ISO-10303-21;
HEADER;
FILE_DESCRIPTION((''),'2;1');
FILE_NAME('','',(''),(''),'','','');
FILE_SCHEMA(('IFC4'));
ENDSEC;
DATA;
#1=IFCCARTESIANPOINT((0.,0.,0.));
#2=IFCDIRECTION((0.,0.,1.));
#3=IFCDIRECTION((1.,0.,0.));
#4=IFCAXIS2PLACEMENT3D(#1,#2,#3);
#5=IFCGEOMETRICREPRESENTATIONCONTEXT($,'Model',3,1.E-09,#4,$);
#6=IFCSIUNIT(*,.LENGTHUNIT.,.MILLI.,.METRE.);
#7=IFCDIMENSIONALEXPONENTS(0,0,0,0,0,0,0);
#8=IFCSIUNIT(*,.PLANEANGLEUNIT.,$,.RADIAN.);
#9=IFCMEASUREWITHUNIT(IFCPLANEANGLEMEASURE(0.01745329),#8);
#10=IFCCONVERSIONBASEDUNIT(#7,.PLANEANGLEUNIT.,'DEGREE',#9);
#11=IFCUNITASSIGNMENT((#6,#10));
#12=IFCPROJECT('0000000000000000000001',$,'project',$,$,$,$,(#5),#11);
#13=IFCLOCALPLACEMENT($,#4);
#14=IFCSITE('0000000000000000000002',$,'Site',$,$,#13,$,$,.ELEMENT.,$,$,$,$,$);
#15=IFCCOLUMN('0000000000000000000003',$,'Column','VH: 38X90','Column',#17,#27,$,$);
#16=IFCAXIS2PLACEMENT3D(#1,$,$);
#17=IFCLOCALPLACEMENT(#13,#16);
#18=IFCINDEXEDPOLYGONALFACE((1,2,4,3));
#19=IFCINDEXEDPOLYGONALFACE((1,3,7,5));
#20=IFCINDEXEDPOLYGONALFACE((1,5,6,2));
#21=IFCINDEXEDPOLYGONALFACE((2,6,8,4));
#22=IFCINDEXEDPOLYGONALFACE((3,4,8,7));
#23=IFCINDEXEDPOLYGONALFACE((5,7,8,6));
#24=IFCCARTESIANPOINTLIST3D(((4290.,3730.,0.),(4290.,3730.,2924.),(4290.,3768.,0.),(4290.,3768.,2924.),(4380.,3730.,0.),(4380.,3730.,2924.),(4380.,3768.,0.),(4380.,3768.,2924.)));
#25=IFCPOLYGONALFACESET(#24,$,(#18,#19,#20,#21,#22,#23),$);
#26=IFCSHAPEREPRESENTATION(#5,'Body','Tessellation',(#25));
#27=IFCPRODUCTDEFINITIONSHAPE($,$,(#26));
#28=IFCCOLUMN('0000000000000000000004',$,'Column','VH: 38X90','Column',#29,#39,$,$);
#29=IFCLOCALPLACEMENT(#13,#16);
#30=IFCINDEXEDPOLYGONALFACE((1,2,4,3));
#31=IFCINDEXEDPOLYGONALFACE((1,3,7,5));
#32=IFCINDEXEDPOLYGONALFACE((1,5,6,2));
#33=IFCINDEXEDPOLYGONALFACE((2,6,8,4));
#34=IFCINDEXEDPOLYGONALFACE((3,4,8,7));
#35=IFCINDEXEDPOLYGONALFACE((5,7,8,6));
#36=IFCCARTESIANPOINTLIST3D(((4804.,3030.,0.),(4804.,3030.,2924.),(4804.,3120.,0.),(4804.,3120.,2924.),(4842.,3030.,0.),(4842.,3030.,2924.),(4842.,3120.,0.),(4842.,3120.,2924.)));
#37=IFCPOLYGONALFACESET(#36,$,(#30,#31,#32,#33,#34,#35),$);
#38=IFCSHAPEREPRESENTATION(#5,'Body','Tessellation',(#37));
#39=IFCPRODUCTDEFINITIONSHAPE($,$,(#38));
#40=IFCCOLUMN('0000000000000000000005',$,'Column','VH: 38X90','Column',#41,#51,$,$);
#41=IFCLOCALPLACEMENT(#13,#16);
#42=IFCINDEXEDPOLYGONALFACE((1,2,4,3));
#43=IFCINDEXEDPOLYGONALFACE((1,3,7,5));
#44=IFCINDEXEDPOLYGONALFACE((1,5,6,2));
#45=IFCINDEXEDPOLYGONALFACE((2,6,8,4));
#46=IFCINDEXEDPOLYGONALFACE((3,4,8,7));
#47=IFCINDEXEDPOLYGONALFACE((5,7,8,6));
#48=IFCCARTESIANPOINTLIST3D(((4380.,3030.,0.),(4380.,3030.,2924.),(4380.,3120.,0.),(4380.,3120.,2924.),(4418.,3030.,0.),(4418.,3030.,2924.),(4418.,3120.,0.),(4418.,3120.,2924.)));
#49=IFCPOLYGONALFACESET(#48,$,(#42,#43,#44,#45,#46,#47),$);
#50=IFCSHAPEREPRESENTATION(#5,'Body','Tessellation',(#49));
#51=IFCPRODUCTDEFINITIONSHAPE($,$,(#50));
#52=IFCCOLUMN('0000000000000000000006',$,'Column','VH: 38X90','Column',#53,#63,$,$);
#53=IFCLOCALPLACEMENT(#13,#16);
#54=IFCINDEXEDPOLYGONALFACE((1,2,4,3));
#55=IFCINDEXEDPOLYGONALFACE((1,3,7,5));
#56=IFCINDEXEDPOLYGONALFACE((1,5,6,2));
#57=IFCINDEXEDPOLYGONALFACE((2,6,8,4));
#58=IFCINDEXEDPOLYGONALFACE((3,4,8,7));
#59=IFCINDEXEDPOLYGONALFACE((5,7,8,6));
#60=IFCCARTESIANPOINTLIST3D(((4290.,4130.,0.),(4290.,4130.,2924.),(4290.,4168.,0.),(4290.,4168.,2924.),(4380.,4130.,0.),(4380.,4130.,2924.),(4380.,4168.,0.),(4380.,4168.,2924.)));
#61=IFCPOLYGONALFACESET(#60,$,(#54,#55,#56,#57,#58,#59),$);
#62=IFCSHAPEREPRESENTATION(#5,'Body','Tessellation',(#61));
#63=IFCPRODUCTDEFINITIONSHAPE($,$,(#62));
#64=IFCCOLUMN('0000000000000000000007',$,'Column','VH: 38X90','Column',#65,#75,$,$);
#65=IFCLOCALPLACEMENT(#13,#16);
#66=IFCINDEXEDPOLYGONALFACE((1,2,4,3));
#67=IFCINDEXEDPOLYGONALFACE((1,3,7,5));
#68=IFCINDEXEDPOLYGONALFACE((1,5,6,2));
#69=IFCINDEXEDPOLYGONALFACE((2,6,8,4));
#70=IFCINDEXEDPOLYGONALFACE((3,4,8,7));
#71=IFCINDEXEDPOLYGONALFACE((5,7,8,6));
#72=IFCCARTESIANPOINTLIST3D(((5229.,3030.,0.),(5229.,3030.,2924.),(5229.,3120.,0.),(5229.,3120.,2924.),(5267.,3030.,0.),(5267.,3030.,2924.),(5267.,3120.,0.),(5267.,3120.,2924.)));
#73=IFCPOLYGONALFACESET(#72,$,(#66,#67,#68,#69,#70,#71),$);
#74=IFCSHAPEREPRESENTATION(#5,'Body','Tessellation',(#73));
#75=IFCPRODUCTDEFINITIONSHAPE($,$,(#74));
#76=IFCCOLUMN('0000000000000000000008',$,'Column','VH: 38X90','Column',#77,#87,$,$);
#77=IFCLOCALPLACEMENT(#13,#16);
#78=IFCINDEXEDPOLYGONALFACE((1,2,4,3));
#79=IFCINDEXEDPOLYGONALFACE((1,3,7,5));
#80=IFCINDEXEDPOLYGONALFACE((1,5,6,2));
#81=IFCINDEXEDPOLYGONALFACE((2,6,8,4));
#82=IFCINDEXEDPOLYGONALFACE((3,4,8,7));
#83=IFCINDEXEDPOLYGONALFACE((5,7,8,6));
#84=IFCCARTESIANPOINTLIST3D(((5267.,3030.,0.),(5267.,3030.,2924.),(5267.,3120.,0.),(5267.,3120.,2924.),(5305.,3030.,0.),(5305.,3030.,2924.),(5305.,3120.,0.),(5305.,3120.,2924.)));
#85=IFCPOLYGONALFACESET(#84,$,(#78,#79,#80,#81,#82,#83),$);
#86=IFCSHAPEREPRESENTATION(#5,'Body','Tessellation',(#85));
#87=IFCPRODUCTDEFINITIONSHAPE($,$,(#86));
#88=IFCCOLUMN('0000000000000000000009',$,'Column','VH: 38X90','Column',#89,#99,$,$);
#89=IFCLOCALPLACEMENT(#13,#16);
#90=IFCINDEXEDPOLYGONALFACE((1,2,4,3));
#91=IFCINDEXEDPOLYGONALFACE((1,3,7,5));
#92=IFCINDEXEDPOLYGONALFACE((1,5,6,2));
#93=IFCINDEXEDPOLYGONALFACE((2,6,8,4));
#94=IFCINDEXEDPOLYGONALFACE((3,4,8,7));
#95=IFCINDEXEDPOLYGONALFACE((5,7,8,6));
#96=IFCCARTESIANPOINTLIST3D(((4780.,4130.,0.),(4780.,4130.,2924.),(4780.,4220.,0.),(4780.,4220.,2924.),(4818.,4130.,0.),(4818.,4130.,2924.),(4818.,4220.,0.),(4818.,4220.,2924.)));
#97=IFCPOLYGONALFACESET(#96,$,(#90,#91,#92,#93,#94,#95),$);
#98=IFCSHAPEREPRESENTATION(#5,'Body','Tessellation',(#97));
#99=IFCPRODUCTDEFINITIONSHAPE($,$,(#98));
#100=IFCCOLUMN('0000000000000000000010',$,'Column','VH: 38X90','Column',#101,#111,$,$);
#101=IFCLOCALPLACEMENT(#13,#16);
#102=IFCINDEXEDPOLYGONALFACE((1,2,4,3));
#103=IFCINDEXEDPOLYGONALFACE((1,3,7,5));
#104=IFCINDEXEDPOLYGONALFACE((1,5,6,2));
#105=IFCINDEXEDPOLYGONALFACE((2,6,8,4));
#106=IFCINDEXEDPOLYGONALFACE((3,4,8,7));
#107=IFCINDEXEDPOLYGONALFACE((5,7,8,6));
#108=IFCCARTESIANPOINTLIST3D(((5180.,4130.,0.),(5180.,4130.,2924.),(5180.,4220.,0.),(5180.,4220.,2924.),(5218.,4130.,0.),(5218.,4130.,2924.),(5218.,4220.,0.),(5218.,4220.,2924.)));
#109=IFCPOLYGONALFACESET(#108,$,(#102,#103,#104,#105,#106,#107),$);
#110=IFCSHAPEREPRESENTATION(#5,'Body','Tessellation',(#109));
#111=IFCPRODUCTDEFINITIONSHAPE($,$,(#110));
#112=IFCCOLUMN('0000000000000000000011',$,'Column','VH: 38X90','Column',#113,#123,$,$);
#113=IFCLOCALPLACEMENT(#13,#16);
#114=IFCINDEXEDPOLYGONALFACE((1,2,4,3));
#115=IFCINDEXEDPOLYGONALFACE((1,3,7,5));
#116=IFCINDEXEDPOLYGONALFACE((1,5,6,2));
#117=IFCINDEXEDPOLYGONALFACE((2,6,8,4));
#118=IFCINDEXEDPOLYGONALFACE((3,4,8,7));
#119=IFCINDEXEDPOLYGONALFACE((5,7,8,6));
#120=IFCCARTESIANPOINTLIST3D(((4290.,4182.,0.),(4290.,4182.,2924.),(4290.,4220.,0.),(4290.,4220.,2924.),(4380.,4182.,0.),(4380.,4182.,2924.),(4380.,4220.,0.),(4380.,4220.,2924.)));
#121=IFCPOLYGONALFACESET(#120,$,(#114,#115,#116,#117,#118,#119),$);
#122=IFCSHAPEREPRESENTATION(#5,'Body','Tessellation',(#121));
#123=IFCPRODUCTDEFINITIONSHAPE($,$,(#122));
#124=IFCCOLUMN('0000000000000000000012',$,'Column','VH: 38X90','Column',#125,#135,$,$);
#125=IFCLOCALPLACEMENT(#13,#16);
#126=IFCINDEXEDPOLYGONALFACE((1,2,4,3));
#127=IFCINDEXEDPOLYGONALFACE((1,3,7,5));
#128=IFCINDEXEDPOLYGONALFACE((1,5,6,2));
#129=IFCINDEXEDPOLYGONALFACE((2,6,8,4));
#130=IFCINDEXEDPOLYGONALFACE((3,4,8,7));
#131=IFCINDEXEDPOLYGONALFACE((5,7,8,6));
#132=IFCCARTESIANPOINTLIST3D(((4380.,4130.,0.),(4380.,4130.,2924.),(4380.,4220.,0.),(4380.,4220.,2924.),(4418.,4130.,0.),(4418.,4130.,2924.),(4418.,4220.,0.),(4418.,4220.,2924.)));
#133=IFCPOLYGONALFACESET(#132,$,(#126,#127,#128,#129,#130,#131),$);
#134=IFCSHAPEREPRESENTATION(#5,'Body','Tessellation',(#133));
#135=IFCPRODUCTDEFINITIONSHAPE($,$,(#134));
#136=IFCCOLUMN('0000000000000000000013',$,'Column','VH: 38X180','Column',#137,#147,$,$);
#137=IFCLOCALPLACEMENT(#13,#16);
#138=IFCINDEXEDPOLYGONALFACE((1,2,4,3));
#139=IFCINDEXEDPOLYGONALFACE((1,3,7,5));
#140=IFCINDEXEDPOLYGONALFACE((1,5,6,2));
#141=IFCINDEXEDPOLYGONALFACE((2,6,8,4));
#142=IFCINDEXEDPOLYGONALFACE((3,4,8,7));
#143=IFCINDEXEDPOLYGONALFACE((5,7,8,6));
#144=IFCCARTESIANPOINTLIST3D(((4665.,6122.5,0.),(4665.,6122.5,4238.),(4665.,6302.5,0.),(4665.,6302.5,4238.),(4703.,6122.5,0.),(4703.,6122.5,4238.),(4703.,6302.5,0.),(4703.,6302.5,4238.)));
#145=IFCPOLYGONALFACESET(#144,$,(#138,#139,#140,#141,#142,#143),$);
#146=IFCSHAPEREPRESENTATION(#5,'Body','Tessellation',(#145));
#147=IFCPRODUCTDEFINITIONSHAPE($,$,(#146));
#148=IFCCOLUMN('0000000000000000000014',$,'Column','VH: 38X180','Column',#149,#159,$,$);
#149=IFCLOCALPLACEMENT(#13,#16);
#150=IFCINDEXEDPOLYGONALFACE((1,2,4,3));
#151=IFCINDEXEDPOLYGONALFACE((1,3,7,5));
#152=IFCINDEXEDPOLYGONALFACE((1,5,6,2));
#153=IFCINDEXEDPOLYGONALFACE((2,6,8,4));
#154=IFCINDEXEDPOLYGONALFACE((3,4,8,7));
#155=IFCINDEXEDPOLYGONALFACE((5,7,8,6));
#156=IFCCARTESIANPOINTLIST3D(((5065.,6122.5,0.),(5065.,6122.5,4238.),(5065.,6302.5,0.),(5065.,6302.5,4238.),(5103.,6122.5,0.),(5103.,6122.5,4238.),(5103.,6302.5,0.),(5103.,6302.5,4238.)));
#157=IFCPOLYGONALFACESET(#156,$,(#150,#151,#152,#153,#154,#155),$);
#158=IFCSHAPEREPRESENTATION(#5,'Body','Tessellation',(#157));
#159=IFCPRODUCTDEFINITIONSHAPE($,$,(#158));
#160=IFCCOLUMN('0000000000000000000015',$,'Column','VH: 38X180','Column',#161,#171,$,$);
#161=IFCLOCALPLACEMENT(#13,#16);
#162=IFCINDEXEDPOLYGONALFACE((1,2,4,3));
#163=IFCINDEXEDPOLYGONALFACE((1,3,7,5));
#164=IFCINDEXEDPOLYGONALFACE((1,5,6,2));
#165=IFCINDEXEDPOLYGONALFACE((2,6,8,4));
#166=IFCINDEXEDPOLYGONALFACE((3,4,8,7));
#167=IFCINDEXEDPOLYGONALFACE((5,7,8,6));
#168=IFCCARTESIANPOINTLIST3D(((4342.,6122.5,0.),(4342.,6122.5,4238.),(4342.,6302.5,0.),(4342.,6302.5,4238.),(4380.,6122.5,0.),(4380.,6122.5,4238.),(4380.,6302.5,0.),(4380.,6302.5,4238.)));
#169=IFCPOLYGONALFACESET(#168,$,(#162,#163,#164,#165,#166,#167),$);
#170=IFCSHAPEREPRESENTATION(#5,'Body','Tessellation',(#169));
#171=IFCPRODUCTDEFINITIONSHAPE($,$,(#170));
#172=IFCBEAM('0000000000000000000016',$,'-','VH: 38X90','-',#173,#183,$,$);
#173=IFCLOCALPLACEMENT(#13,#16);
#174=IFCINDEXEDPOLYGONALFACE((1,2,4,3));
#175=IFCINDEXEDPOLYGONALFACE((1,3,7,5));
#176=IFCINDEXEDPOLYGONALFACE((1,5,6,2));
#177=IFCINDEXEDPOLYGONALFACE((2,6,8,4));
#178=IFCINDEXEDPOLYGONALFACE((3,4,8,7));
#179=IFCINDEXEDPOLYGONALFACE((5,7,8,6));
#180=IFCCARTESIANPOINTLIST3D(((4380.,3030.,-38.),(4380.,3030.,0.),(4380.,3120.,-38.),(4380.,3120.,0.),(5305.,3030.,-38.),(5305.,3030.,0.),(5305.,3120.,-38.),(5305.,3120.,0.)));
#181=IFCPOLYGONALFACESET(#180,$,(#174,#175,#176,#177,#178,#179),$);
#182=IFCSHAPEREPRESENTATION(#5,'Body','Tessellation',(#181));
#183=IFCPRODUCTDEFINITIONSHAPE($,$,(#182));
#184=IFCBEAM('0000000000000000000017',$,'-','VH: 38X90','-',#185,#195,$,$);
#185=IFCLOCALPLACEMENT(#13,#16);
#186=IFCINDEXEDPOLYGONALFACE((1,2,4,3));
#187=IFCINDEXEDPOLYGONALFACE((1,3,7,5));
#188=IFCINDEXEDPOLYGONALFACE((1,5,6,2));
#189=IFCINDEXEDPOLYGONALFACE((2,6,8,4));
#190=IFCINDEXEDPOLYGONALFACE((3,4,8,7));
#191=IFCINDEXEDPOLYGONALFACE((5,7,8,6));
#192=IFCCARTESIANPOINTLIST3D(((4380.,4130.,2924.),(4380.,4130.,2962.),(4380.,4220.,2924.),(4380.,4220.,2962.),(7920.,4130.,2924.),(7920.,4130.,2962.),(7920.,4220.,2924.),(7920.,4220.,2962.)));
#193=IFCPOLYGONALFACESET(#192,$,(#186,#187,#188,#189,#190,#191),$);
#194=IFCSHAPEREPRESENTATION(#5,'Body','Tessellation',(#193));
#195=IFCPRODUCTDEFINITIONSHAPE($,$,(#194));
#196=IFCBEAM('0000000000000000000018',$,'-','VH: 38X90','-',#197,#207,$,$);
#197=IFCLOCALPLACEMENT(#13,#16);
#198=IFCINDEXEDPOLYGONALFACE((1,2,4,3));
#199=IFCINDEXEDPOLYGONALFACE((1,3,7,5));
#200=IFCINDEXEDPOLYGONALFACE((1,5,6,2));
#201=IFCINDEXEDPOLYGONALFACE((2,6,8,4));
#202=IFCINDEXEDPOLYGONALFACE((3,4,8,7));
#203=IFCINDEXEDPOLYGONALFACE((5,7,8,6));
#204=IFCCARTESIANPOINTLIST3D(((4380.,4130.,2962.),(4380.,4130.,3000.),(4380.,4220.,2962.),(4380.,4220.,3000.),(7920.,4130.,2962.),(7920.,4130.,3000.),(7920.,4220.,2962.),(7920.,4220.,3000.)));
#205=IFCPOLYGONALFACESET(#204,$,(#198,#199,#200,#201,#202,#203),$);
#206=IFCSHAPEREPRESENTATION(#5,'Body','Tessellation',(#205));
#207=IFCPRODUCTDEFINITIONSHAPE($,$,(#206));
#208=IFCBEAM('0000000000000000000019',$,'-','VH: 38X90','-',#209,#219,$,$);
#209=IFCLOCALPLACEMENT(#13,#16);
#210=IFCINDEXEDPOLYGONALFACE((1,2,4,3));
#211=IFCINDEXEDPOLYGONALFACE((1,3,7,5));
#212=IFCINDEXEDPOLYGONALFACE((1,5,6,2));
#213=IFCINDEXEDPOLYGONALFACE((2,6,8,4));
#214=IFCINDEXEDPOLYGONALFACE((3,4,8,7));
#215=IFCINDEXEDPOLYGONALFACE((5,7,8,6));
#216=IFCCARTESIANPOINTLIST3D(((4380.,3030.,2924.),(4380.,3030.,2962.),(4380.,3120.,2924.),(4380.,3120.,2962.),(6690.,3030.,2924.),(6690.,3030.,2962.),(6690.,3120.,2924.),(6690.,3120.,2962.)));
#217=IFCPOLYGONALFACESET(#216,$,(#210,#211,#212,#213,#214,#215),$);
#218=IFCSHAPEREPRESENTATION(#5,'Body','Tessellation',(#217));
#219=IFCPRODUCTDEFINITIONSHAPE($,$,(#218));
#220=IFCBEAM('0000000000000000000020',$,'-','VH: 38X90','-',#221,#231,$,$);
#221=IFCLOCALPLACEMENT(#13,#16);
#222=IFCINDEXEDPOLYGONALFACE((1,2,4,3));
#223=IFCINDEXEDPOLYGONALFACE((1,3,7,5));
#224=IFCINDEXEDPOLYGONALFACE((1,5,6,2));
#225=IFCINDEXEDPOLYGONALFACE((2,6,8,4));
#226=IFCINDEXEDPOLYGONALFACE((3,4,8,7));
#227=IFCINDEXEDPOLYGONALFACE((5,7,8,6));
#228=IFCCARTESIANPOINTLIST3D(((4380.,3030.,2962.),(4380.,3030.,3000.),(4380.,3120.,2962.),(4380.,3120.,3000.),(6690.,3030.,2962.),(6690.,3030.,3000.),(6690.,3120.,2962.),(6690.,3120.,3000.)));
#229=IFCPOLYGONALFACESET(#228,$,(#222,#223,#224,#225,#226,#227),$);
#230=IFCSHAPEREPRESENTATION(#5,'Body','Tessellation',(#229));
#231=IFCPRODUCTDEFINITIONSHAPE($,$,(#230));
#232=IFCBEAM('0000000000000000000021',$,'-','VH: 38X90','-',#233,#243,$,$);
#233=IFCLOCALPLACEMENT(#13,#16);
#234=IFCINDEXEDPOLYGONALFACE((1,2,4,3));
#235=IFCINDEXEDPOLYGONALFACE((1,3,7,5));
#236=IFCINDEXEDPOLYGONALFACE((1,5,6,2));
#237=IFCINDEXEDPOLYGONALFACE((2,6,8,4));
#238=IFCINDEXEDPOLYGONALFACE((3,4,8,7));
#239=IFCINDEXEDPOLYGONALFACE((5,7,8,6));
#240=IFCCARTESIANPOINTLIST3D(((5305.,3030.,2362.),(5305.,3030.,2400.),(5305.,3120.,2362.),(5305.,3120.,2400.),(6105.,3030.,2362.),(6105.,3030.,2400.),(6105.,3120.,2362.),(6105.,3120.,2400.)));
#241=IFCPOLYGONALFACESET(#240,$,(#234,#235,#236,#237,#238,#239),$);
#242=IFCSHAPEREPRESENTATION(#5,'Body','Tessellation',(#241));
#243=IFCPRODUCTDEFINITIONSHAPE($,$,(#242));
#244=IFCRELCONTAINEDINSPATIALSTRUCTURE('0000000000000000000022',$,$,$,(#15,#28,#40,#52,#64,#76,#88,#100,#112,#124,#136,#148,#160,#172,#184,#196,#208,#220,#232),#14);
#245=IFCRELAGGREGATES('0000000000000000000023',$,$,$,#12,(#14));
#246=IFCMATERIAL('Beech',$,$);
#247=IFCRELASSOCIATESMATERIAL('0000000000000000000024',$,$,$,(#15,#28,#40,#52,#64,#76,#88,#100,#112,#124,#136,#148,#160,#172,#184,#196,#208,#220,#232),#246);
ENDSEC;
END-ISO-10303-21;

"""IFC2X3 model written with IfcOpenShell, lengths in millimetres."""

from ifc_helpers import new_model, entity, si_unit, converted_unit, frame, origin, origin_with_axes, origin_2d, place, context, project, spatial, rectangle, extrude, material, element, save


model = new_model("IFC2X3")

# Units and contexts
model_context = context("Model", 3, precision=1e-09, world=origin_with_axes())
ifc_project = project(units=[si_unit("LENGTHUNIT", "METRE", prefix="MILLI"), converted_unit("PLANEANGLEUNIT", "DEGREE", entity("IfcPlaneAngleMeasure", 0.01745329), si_unit("PLANEANGLEUNIT", "RADIAN"), dimensions=[0, 0, 0, 0, 0, 0, 0])], contexts=[model_context])

# Site
site_placement = place(None, origin_with_axes())
site = spatial("IfcSite", under=ifc_project, at=site_placement, Name="Site", CompositionType="ELEMENT")

# Columns
ifc_material = material(Name="Beech")
for number, where, z_axis, x_axis, name in (
    (1, (4335.0, 3749.0, 0.0), (0.0, 0.0, -1.0), (0.0, -1.0, 0.0), "Column"),
    (2, (4823.0, 3075.0, 0.0), (0.0, 0.0, -1.0), (-1.0, 0.0, 0.0), "Column"),
    (3, (4399.0, 3075.0, 0.0), (0.0, 0.0, -1.0), (-1.0, 0.0, 0.0), "Column"),
    (4, (4335.0, 4149.0, 0.0), (0.0, 0.0, -1.0), (0.0, -1.0, 0.0), "Column"),
    (5, (5248.0, 3075.0, 0.0), (0.0, 0.0, -1.0), (-1.0, 0.0, 0.0), "Column"),
    (6, (5286.0, 3075.0, 0.0), (0.0, 0.0, -1.0), (-1.0, 0.0, 0.0), "Column"),
    (7, (4799.0, 4175.0, 0.0), (0.0, 0.0, -1.0), (-1.0, 0.0, 0.0), "Column"),
    (8, (5199.0, 4175.0, 0.0), (0.0, 0.0, -1.0), (-1.0, 0.0, 0.0), "Column"),
    (9, (4335.0, 4201.0, 0.0), (0.0, 0.0, -1.0), (0.0, -1.0, 0.0), "Column"),
    (10, (4399.0, 4175.0, 0.0), (0.0, 0.0, -1.0), (-1.0, 0.0, 0.0), "Column"),
):
    element("IfcColumn", number, at=place(None, frame(where, z_axis=z_axis, x_axis=x_axis)), inside=site, material=ifc_material, Name=name, Description="VH: 38X90", ObjectType="Column", context=model_context, shape_type="SweptSolid", body=[
        extrude(rectangle(XDim=38.0, YDim=90.0, at=origin_2d()), origin(), (0.0, 0.0, -1.0), 2924.0),
    ])
for number, where, z_axis, x_axis, name in (
    (11, (4684.0, 6212.5, 0.0), (0.0, 0.0, -1.0), (-1.0, 0.0, 0.0), "Column"),
    (12, (5084.0, 6212.5, 0.0), (0.0, 0.0, -1.0), (-1.0, 0.0, 0.0), "Column"),
    (13, (4361.0, 6212.5, 0.0), (0.0, 0.0, -1.0), (-1.0, 0.0, 0.0), "Column"),
):
    element("IfcColumn", number, at=place(None, frame(where, z_axis=z_axis, x_axis=x_axis)), inside=site, material=ifc_material, Name=name, Description="VH: 38X180", ObjectType="Column", context=model_context, shape_type="SweptSolid", body=[
        extrude(rectangle(XDim=38.0, YDim=180.0, at=origin_2d()), origin(), (0.0, 0.0, -1.0), 4238.0),
    ])

# Beams
beam_1_placement = place(None, frame((4380.0, 3075.0, -19.0), z_axis=(-1.0, 0.0, 0.0), x_axis=(0.0, 0.0, -1.0)))
element("IfcBeam", 14, at=beam_1_placement, inside=site, material=ifc_material, Name="-", Description="VH: 38X90", ObjectType="-", context=model_context, shape_type="SweptSolid", body=[
    extrude(rectangle(XDim=38.0, YDim=90.0, at=origin_2d()), origin(), (0.0, 0.0, -1.0), 925.0),
])
for number, where, z_axis, x_axis, name in (
    (15, (4380.0, 4175.0, 2943.0), (-1.0, 0.0, 0.0), (0.0, 0.0, -1.0), "-"),
    (16, (4380.0, 4175.0, 2981.0), (-1.0, 0.0, 0.0), (0.0, 0.0, -1.0), "-"),
):
    element("IfcBeam", number, at=place(None, frame(where, z_axis=z_axis, x_axis=x_axis)), inside=site, material=ifc_material, Name=name, Description="VH: 38X90", ObjectType="-", context=model_context, shape_type="SweptSolid", body=[
        extrude(rectangle(XDim=38.0, YDim=90.0, at=origin_2d()), origin(), (0.0, 0.0, -1.0), 3540.0),
    ])
for number, where, z_axis, x_axis, name in (
    (17, (4380.0, 3075.0, 2943.0), (-1.0, 0.0, 0.0), (0.0, 0.0, -1.0), "-"),
    (18, (4380.0, 3075.0, 2981.0), (-1.0, 0.0, 0.0), (0.0, 0.0, -1.0), "-"),
):
    element("IfcBeam", number, at=place(None, frame(where, z_axis=z_axis, x_axis=x_axis)), inside=site, material=ifc_material, Name=name, Description="VH: 38X90", ObjectType="-", context=model_context, shape_type="SweptSolid", body=[
        extrude(rectangle(XDim=38.0, YDim=90.0, at=origin_2d()), origin(), (0.0, 0.0, -1.0), 2310.0),
    ])
beam_2_placement = place(None, frame((5305.0, 3075.0, 2381.0), z_axis=(-1.0, -0.000033, 0.0), x_axis=(0.0, 0.0, -1.0)))
element("IfcBeam", 19, at=beam_2_placement, inside=site, material=ifc_material, Name="-", Description="VH: 38X90", ObjectType="-", context=model_context, shape_type="SweptSolid", body=[
    extrude(rectangle(XDim=38.0, YDim=90.0, at=origin_2d()), origin(), (0.0, 0.0, -1.0), 800.0),
])

save(model, "model.ifc")
